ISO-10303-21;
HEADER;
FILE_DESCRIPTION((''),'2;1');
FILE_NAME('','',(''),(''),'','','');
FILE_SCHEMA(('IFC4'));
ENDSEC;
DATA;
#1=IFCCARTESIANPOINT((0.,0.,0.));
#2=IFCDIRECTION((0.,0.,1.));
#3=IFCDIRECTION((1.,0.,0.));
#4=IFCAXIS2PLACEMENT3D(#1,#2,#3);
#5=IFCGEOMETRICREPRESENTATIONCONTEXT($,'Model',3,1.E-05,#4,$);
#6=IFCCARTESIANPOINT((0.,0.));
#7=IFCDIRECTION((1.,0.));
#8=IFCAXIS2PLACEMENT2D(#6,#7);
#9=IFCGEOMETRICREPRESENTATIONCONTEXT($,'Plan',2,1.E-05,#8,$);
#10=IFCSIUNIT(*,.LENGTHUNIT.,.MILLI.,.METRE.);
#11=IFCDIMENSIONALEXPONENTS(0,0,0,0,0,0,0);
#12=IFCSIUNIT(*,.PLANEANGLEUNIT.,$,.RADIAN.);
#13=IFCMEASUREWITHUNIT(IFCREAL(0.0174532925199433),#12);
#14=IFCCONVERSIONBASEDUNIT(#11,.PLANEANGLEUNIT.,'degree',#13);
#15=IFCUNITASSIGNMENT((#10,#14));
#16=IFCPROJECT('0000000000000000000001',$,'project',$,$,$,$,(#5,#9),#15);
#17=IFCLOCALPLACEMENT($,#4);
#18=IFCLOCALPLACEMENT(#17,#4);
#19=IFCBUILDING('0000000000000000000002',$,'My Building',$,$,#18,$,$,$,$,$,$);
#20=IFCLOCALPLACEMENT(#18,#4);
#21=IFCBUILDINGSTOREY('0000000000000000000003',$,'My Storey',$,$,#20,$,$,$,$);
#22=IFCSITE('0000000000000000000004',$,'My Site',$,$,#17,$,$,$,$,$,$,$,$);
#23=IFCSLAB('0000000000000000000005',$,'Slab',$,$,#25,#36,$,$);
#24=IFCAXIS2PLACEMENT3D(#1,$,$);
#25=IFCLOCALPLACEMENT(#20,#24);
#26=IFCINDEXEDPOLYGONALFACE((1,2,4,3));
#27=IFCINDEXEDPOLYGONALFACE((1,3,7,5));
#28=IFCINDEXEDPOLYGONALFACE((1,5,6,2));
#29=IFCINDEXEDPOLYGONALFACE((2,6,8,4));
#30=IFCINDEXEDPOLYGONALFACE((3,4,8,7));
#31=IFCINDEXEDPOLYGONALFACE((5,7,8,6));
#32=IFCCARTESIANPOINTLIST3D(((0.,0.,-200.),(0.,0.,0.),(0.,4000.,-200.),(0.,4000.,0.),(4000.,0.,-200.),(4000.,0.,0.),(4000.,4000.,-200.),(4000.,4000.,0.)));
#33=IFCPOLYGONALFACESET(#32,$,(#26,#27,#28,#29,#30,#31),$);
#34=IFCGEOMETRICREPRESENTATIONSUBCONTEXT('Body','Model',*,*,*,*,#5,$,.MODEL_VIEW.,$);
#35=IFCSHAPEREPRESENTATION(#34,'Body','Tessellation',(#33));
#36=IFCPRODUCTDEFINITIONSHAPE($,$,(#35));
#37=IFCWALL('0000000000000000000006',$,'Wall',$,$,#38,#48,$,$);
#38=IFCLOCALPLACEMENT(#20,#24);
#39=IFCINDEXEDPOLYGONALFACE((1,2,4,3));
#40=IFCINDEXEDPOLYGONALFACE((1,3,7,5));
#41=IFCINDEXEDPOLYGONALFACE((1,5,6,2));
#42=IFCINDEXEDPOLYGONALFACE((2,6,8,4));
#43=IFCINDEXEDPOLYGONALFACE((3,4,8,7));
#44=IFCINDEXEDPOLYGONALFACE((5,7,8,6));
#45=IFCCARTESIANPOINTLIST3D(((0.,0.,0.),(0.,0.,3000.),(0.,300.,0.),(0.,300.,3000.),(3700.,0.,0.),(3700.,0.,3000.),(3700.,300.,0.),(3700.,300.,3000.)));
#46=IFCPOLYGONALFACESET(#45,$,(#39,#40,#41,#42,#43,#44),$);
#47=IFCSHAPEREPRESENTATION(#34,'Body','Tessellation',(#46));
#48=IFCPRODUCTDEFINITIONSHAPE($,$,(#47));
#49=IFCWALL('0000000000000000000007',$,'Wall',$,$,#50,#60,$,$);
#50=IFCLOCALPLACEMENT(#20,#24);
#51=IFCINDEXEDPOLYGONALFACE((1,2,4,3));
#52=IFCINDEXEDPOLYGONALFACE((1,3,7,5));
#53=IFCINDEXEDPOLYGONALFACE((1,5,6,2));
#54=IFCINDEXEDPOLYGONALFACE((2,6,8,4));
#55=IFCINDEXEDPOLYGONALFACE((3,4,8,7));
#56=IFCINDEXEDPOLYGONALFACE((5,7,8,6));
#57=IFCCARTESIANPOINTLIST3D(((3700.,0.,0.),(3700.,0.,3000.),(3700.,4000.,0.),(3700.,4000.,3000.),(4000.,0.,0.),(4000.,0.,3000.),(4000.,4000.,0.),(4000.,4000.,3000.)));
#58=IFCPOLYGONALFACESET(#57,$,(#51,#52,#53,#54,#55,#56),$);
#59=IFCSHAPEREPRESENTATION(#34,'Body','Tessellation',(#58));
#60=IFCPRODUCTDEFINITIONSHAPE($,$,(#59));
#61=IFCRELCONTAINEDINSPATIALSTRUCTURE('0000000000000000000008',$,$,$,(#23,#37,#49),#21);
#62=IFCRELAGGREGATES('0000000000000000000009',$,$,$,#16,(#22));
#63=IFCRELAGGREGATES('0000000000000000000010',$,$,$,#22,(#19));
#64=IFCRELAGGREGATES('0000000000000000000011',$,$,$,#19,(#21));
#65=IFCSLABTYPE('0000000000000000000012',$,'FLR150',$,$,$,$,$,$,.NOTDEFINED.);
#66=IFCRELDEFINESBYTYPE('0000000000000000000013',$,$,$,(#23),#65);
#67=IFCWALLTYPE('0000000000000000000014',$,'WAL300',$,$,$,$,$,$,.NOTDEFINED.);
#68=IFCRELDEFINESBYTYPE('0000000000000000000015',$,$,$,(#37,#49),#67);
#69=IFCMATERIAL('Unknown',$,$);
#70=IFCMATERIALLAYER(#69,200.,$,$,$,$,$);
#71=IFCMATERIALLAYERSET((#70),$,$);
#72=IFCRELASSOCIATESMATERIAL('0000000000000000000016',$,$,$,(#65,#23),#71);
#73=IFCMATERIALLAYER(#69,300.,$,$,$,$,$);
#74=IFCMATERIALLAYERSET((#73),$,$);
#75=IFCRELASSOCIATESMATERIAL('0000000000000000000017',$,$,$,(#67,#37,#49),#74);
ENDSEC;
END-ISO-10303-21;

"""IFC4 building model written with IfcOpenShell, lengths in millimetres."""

from ifc_helpers import new_model, entity, si_unit, converted_unit, frame, origin_with_axes, origin_2d_with_axis, place, context, subcontext, project, spatial, line, indexed_curve, outline, extrude, material, layer, layer_set, layer_usage, type_object, element, save


model = new_model("IFC4")

# Units and contexts
model_context = context("Model", 3, precision=1e-05, world=origin_with_axes())
plan_context = context("Plan", 2, precision=1e-05, world=origin_2d_with_axis())
body_context = subcontext(model_context, "Body", "Model", "MODEL_VIEW")
ifc_project = project(units=[si_unit("LENGTHUNIT", "METRE", prefix="MILLI"), converted_unit("PLANEANGLEUNIT", "degree", entity("IfcReal", 0.0174532925199433), si_unit("PLANEANGLEUNIT", "RADIAN"), dimensions=[0, 0, 0, 0, 0, 0, 0])], contexts=[model_context, plan_context])

# Site, building, storey
site_placement = place(None, origin_with_axes())
site = spatial("IfcSite", under=ifc_project, at=site_placement, Name="My Site")
building_placement = place(site_placement, origin_with_axes())
building = spatial("IfcBuilding", under=site, at=building_placement, Name="My Building")
storey_placement = place(building_placement, origin_with_axes())
storey = spatial("IfcBuildingStorey", under=building, at=storey_placement, Name="My Storey")

# Slab
ifc_material = material(Name="Unknown")
ifc_layer_1 = layer(ifc_material, 200.0)
ifc_layer_set_1 = layer_set([ifc_layer_1])
ifc_layer_usage_1 = layer_usage(ifc_layer_set_1, "AXIS3", "POSITIVE", 0.0)
slab_type = type_object("IfcSlabType", Name="FLR150", PredefinedType="NOTDEFINED", material=ifc_layer_set_1)
slab_placement = place(storey_placement, frame((0.0, 0.0, -200.0), z_axis=(0.0, 0.0, 1.0), x_axis=(1.0, 0.0, 0.0)))
element("IfcSlab", 1, at=slab_placement, inside=storey, type_object=slab_type, material=ifc_layer_usage_1, Name="Slab", context=body_context, shape_type="SweptSolid", body=[
    extrude(outline(indexed_curve([(0.0, 0.0), (4000.0, 0.0), (4000.0, 4000.0), (0.0, 4000.0)], segments=[line(4, 1), line(1, 2), line(2, 3), line(3, 4)], self_intersect=False)), None, (0.0, 0.0, 1.0), 200.0),
])

# Walls
ifc_layer_2 = layer(ifc_material, 300.0)
ifc_layer_set_2 = layer_set([ifc_layer_2])
ifc_layer_usage_2 = layer_usage(ifc_layer_set_2, "AXIS2", "POSITIVE", 0.0)
wall_type = type_object("IfcWallType", Name="WAL300", PredefinedType="NOTDEFINED", material=ifc_layer_set_2)
wall_1_placement = place(storey_placement, origin_with_axes())
element("IfcWall", 2, at=wall_1_placement, inside=storey, type_object=wall_type, material=ifc_layer_usage_2, Name="Wall", context=body_context, shape_type="SweptSolid", body=[
    extrude(outline(indexed_curve([(0.0, 0.0), (0.0, 300.0), (3700.0, 300.0), (3700.0, 0.0), (0.0, 0.0)], self_intersect=False)), origin_with_axes(), (0.0, 0.0, 1.0), 3000.0),
])
ifc_layer_usage_3 = layer_usage(ifc_layer_set_2, "AXIS2", "POSITIVE", 0.0)
wall_2_placement = place(storey_placement, frame((4000.0, 0.0, 0.0), z_axis=(0.0, 0.0, 1.0), x_axis=(0.0, 1.0, 0.0)))
element("IfcWall", 3, at=wall_2_placement, inside=storey, type_object=wall_type, material=ifc_layer_usage_3, Name="Wall", context=body_context, shape_type="SweptSolid", body=[
    extrude(outline(indexed_curve([(0.0, 0.0), (0.0, 300.0), (4000.0, 300.0), (4000.0, 0.0), (0.0, 0.0)], self_intersect=False)), origin_with_axes(), (0.0, 0.0, 1.0), 3000.0),
])

save(model, "model.ifc")
